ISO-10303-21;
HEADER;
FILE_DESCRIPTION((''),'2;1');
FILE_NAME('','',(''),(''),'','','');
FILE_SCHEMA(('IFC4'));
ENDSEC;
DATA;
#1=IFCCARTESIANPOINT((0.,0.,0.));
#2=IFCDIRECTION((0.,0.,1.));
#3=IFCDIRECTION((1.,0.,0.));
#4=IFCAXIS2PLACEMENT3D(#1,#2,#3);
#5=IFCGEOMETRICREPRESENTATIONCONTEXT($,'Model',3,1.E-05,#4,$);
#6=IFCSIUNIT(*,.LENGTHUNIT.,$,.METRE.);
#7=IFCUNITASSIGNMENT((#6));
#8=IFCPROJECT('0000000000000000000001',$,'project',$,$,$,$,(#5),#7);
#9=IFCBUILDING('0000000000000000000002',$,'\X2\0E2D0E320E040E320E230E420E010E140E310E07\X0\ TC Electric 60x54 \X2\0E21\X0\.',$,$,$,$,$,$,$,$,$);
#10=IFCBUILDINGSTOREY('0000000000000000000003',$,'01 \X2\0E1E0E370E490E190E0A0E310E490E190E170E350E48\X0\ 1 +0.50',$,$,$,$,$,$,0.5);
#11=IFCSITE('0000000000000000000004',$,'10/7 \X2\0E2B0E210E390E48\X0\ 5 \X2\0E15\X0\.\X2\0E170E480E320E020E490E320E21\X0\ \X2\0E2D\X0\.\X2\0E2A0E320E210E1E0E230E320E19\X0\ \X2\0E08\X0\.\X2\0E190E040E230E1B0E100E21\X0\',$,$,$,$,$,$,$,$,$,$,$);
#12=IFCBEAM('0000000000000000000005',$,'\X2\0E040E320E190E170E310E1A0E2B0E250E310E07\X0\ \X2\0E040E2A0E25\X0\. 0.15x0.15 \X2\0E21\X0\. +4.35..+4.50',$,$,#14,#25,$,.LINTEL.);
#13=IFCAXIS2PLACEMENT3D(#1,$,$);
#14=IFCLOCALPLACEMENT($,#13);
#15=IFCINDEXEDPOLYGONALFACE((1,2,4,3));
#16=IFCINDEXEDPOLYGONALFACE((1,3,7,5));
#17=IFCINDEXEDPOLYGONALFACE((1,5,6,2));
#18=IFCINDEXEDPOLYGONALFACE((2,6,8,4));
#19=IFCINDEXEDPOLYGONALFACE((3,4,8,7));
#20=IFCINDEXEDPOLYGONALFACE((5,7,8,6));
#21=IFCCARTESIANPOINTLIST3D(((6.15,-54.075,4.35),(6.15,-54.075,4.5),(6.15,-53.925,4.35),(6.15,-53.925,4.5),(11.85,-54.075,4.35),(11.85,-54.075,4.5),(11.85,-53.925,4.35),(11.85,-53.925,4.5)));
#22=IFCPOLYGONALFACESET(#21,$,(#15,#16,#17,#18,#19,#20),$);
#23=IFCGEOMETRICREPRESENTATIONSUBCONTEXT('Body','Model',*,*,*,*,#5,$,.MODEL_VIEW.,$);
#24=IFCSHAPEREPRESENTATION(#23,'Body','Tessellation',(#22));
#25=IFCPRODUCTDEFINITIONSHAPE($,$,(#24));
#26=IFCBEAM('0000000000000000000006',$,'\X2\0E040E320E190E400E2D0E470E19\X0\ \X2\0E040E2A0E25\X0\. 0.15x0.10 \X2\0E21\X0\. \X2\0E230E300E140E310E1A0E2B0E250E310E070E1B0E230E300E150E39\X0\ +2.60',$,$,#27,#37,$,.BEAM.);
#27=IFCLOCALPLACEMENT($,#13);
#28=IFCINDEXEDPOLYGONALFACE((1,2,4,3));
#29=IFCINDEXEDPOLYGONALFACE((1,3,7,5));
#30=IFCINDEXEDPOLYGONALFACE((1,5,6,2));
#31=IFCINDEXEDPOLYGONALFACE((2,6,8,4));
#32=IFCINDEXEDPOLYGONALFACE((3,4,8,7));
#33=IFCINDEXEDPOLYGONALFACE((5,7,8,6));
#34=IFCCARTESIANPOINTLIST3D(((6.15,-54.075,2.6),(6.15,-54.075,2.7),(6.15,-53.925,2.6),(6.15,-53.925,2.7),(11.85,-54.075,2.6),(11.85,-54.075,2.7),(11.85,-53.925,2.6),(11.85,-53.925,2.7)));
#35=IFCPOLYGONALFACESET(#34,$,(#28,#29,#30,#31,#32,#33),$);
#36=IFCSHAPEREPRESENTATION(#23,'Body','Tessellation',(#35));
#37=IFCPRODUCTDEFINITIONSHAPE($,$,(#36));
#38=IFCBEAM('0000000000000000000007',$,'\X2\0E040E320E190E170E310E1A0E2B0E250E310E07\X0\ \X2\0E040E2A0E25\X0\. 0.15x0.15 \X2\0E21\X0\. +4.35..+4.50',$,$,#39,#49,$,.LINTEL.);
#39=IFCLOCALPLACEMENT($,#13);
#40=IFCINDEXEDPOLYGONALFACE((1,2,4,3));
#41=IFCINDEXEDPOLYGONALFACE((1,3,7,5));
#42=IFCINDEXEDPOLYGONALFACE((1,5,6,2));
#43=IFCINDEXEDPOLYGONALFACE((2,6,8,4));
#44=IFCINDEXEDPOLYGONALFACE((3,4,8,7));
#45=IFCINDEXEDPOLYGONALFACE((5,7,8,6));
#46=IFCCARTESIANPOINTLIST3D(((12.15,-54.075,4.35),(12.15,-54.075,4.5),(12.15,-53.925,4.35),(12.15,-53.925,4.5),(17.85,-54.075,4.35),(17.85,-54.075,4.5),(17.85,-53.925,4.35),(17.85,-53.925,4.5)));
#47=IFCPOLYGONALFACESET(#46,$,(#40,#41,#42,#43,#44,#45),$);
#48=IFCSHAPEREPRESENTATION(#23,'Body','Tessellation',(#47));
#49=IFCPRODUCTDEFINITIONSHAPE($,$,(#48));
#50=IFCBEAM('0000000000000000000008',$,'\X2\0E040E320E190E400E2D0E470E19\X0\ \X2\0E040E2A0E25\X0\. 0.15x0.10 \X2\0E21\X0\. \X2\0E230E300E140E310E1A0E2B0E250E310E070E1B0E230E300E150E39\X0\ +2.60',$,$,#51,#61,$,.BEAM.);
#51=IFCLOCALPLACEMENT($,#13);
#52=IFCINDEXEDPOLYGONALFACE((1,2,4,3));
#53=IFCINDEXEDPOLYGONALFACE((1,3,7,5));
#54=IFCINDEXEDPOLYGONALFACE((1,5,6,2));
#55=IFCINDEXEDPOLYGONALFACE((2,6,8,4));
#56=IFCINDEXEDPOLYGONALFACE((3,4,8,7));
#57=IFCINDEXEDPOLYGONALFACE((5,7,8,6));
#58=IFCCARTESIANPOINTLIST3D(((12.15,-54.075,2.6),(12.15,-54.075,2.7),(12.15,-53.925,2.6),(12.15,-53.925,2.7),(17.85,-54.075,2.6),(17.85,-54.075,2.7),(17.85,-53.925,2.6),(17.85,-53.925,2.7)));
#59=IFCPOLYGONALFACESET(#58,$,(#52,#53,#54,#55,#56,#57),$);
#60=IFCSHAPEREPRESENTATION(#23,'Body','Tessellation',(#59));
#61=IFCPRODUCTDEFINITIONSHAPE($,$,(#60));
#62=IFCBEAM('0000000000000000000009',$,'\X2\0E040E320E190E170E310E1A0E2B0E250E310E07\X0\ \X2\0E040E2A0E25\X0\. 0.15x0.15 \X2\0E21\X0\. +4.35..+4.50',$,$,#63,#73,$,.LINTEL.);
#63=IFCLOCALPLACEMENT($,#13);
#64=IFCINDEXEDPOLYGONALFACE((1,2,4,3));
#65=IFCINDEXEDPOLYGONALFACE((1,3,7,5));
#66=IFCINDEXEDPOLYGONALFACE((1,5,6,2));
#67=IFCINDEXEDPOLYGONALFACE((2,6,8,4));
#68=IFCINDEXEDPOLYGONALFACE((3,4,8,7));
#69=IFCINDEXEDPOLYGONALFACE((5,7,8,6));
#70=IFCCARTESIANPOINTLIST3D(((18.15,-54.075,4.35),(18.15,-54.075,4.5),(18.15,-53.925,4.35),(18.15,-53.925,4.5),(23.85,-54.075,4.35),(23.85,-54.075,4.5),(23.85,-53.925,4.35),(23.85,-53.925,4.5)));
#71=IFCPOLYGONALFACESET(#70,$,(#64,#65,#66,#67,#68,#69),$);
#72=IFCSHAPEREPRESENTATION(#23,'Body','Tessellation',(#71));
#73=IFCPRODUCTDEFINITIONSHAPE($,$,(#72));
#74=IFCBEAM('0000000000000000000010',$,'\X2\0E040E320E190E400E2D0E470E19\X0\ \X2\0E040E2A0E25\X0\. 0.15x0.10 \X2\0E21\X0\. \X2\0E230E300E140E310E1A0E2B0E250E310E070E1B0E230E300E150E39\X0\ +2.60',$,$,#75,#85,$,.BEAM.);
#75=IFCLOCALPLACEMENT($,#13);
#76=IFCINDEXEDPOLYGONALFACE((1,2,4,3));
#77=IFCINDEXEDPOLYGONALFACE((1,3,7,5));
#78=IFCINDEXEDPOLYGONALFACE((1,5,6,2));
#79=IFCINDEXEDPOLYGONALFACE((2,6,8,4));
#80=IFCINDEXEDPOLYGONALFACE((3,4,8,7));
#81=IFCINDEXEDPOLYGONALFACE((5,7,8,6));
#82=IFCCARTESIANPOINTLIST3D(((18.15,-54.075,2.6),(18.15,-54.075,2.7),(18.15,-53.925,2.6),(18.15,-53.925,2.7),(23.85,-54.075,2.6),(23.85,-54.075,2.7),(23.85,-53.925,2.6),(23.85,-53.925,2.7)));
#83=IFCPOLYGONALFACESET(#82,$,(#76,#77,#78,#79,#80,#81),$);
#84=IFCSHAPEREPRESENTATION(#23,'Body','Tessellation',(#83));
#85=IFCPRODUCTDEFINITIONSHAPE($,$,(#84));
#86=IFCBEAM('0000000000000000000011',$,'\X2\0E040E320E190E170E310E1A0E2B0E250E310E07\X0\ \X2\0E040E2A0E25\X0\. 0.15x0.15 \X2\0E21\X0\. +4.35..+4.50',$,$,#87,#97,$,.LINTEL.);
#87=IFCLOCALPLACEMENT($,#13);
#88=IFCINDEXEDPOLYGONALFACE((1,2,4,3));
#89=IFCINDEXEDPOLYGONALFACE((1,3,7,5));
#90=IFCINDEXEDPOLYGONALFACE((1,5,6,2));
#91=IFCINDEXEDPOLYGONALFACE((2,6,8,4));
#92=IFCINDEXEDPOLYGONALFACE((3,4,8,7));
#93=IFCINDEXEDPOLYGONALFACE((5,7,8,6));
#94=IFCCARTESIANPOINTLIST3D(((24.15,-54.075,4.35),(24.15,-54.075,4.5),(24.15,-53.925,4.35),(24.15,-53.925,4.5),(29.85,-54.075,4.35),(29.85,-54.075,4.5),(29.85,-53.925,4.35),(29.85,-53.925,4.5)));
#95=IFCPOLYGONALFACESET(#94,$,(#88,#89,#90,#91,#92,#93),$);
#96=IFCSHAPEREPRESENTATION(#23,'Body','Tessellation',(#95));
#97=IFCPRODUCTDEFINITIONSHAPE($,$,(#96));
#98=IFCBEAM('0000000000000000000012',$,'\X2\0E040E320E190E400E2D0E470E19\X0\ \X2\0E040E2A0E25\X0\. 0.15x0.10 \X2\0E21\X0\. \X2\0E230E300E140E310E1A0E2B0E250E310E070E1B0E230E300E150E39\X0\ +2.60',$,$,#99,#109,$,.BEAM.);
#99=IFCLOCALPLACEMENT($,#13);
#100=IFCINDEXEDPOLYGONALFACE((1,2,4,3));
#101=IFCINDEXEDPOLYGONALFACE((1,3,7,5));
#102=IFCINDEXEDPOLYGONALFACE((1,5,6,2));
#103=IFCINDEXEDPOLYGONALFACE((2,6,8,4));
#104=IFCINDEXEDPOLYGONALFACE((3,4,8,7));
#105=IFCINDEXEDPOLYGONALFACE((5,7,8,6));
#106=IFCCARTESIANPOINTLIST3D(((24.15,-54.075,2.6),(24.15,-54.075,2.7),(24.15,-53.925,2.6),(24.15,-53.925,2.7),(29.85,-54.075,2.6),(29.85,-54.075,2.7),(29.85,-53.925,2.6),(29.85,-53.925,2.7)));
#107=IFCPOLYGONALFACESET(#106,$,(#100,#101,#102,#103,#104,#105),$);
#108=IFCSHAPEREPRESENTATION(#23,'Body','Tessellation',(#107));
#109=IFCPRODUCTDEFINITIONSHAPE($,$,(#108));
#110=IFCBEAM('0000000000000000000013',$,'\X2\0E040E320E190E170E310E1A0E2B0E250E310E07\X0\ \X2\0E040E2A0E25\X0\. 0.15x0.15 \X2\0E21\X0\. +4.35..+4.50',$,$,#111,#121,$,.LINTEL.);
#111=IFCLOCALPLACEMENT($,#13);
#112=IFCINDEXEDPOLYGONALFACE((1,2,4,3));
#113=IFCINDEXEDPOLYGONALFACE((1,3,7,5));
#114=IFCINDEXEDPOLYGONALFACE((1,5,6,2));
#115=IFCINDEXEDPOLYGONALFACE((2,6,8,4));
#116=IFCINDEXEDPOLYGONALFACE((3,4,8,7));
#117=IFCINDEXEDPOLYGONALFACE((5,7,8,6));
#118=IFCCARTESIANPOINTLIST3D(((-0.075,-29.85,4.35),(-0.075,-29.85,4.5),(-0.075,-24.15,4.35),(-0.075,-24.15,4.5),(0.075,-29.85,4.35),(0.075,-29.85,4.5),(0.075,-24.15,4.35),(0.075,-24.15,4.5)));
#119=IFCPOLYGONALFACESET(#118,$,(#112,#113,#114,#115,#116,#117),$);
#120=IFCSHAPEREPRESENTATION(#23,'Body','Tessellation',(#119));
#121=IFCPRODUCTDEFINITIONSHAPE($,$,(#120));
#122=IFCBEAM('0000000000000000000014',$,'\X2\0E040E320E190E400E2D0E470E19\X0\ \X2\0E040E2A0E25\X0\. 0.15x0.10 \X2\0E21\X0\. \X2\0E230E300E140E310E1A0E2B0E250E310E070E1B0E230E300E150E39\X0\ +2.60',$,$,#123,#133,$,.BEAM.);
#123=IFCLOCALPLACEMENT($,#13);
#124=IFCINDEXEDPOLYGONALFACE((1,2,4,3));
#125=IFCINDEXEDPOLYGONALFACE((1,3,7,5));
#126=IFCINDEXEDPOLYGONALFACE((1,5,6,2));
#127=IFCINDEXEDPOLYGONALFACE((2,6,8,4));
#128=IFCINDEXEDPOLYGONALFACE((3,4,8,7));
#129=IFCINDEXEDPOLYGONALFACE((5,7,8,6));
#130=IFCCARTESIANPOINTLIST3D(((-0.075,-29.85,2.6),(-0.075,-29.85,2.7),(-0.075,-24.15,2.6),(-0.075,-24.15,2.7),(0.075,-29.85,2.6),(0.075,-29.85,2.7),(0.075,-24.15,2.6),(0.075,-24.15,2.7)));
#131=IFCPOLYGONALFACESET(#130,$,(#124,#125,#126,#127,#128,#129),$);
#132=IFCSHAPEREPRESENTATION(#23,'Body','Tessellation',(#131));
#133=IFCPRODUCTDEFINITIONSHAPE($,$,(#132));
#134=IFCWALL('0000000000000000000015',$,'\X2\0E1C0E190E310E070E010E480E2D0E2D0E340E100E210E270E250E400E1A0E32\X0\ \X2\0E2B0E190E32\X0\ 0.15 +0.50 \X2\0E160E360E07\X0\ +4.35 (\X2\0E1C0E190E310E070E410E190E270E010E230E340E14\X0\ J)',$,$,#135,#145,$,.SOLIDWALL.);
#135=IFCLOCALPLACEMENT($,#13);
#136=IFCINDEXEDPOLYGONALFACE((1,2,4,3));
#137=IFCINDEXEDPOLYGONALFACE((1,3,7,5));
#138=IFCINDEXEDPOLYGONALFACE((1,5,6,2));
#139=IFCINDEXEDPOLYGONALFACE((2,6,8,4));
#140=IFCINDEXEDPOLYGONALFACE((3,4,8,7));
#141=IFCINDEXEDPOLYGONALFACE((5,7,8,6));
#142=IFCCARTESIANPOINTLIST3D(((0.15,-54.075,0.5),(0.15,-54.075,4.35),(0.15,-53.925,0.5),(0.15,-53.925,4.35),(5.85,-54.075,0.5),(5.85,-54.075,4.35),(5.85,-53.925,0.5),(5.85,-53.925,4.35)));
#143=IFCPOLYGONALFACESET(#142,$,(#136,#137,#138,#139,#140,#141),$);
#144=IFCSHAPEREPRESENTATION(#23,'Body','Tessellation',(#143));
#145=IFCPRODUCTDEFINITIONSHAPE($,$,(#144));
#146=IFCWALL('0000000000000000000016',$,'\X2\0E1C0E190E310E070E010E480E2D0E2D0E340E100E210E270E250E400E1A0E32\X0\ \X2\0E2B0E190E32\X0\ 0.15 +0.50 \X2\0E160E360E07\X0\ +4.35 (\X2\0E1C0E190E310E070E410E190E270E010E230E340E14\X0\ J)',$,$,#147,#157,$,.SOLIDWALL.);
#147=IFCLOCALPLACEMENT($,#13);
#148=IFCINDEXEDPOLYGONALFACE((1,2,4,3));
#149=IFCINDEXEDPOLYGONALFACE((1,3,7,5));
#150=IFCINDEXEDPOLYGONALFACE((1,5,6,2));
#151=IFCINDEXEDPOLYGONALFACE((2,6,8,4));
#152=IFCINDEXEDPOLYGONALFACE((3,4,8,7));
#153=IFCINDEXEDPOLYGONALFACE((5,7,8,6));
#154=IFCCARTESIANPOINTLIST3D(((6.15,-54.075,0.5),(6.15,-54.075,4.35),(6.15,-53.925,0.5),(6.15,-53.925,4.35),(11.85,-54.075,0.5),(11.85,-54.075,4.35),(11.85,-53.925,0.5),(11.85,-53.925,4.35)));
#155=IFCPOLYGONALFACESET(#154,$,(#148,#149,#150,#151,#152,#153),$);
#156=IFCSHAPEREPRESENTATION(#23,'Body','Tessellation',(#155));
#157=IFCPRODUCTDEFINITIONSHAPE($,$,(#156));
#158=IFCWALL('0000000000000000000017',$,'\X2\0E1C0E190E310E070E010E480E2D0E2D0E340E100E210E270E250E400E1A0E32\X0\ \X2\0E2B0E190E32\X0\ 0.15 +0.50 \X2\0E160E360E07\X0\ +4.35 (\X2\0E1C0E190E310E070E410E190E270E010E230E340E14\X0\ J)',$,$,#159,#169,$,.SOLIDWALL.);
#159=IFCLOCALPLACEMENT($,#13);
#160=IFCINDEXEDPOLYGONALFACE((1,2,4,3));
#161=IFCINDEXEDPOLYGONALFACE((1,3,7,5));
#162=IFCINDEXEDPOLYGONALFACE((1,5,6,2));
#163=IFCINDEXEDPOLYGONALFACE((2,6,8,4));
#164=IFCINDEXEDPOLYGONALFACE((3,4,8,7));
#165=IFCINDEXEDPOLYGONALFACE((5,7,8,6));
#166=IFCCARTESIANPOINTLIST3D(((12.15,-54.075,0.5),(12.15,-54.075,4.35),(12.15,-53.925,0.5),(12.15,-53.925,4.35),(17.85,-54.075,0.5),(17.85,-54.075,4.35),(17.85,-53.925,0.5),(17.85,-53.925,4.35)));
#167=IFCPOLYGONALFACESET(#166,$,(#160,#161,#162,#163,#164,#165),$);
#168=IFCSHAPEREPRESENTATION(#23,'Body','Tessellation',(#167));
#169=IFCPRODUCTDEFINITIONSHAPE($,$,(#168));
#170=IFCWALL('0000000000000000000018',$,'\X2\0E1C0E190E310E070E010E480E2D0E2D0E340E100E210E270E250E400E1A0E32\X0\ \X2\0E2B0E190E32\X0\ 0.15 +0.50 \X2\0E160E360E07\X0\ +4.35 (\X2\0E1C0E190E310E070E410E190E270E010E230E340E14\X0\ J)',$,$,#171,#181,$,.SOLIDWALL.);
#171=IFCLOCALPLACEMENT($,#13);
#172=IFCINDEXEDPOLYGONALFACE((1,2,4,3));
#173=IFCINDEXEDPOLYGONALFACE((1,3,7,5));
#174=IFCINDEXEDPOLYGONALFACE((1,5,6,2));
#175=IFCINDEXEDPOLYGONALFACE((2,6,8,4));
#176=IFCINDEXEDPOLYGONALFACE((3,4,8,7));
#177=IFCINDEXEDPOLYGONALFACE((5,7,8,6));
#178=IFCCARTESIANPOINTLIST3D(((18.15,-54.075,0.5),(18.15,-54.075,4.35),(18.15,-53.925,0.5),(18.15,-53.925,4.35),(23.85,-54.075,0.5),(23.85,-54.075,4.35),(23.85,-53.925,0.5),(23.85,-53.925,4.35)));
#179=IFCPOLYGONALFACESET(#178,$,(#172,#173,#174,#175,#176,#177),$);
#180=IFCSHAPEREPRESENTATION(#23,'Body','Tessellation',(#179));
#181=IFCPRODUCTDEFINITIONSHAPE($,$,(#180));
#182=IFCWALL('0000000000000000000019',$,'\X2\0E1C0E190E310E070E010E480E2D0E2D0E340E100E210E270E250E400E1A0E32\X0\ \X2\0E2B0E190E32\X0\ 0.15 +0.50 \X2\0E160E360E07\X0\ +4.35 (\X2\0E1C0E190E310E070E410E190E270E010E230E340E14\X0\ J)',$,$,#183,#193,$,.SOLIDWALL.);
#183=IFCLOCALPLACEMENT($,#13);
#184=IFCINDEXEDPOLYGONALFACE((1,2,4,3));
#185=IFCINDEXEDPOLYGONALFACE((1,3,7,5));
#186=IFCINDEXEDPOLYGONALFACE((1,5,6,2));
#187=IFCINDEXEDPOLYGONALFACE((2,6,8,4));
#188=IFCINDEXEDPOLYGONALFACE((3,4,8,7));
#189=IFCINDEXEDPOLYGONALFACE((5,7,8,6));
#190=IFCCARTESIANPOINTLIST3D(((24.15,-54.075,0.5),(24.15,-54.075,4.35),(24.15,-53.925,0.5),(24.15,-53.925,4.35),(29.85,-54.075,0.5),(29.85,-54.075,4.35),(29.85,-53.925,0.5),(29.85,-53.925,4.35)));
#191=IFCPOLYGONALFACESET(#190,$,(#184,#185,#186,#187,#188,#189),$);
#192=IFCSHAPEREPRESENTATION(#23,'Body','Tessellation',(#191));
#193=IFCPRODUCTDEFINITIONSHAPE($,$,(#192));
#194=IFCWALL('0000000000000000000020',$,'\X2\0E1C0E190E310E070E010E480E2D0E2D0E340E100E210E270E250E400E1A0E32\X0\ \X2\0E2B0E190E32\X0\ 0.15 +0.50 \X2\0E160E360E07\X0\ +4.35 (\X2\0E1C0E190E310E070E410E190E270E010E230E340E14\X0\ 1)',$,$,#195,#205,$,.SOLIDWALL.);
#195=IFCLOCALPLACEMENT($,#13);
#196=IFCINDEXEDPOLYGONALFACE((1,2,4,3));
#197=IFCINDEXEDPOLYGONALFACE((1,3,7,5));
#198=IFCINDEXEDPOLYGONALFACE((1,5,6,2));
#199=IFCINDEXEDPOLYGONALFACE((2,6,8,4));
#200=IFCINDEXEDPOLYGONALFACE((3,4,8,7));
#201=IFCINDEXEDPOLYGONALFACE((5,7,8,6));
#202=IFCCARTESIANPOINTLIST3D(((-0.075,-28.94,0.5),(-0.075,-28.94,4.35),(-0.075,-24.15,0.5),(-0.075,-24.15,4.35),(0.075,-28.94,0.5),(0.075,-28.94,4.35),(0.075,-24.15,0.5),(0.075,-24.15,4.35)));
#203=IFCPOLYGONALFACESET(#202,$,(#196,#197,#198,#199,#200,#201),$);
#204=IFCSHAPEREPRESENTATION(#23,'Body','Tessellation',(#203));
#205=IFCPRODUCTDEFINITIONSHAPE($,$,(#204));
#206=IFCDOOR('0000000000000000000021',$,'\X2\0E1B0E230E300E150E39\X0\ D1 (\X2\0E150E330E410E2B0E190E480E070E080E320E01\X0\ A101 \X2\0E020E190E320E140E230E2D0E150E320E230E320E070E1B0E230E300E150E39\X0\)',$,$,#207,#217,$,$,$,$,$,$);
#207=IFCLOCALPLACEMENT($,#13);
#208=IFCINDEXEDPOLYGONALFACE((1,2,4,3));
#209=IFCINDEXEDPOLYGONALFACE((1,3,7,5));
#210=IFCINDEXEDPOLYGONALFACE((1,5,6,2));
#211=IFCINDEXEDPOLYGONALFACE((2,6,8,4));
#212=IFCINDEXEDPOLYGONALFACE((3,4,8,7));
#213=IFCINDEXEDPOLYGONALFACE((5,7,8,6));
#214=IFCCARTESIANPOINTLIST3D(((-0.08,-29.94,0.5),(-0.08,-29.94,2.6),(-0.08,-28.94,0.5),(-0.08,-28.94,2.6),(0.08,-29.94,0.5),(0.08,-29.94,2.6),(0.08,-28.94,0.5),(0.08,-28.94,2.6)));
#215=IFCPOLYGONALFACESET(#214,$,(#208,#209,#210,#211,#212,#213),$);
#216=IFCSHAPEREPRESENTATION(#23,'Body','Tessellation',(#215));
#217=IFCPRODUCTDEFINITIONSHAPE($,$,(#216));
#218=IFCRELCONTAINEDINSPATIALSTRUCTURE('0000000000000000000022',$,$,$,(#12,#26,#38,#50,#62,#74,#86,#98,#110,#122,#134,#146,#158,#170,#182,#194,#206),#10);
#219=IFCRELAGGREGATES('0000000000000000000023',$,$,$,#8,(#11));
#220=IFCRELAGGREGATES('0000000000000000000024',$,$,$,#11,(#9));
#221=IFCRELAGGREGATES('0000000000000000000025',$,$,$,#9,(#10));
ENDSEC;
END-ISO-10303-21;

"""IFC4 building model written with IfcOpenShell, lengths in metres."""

from ifc_helpers import new_model, si_unit, frame, origin, origin_with_axes, origin_2d, place, context, subcontext, project, spatial, rectangle, extrude, element, save


model = new_model("IFC4")

# Units and contexts
model_context = context("Model", 3, precision=1e-05, world=origin_with_axes())
body_context = subcontext(model_context, "Body", "Model", "MODEL_VIEW")
ifc_project = project(units=[si_unit("LENGTHUNIT", "METRE")], contexts=[model_context])

# Site, building, storey
site = spatial("IfcSite", under=ifc_project, Name="10/7 หมู่ 5 ต.ท่าข้าม อ.สามพราน จ.นครปฐม")
building = spatial("IfcBuilding", under=site, Name="อาคารโกดัง TC Electric 60x54 ม.")
storey = spatial("IfcBuildingStorey", under=building, Name="01 พื้นชั้นที่ 1 +0.50", Elevation=0.5)

# Beams
beam_1_placement = place(None, frame((6.15, -54.0, 4.425), z_axis=(1.0, 0.0, 0.0), x_axis=(0.0, -1.0, 0.0)))
element("IfcBeam", 1, at=beam_1_placement, inside=storey, Name="คานทับหลัง คสล. 0.15x0.15 ม. +4.35..+4.50", PredefinedType="LINTEL", context=body_context, shape_type="SweptSolid", body=[
    extrude(rectangle(XDim=0.15, YDim=0.15, at=origin_2d()), origin(), (0.0, 0.0, 1.0), 5.7),
])
beam_2_placement = place(None, frame((6.15, -54.0, 2.65), z_axis=(1.0, 0.0, 0.0), x_axis=(0.0, -1.0, 0.0)))
element("IfcBeam", 2, at=beam_2_placement, inside=storey, Name="คานเอ็น คสล. 0.15x0.10 ม. ระดับหลังประตู +2.60", PredefinedType="BEAM", context=body_context, shape_type="SweptSolid", body=[
    extrude(rectangle(XDim=0.15, YDim=0.1, at=origin_2d()), origin(), (0.0, 0.0, 1.0), 5.7),
])
beam_3_placement = place(None, frame((12.15, -54.0, 4.425), z_axis=(1.0, 0.0, 0.0), x_axis=(0.0, -1.0, 0.0)))
element("IfcBeam", 3, at=beam_3_placement, inside=storey, Name="คานทับหลัง คสล. 0.15x0.15 ม. +4.35..+4.50", PredefinedType="LINTEL", context=body_context, shape_type="SweptSolid", body=[
    extrude(rectangle(XDim=0.15, YDim=0.15, at=origin_2d()), origin(), (0.0, 0.0, 1.0), 5.7),
])
beam_4_placement = place(None, frame((12.15, -54.0, 2.65), z_axis=(1.0, 0.0, 0.0), x_axis=(0.0, -1.0, 0.0)))
element("IfcBeam", 4, at=beam_4_placement, inside=storey, Name="คานเอ็น คสล. 0.15x0.10 ม. ระดับหลังประตู +2.60", PredefinedType="BEAM", context=body_context, shape_type="SweptSolid", body=[
    extrude(rectangle(XDim=0.15, YDim=0.1, at=origin_2d()), origin(), (0.0, 0.0, 1.0), 5.7),
])
beam_5_placement = place(None, frame((18.15, -54.0, 4.425), z_axis=(1.0, 0.0, 0.0), x_axis=(0.0, -1.0, 0.0)))
element("IfcBeam", 5, at=beam_5_placement, inside=storey, Name="คานทับหลัง คสล. 0.15x0.15 ม. +4.35..+4.50", PredefinedType="LINTEL", context=body_context, shape_type="SweptSolid", body=[
    extrude(rectangle(XDim=0.15, YDim=0.15, at=origin_2d()), origin(), (0.0, 0.0, 1.0), 5.7),
])
beam_6_placement = place(None, frame((18.15, -54.0, 2.65), z_axis=(1.0, 0.0, 0.0), x_axis=(0.0, -1.0, 0.0)))
element("IfcBeam", 6, at=beam_6_placement, inside=storey, Name="คานเอ็น คสล. 0.15x0.10 ม. ระดับหลังประตู +2.60", PredefinedType="BEAM", context=body_context, shape_type="SweptSolid", body=[
    extrude(rectangle(XDim=0.15, YDim=0.1, at=origin_2d()), origin(), (0.0, 0.0, 1.0), 5.7),
])
beam_7_placement = place(None, frame((24.15, -54.0, 4.425), z_axis=(1.0, 0.0, 0.0), x_axis=(0.0, -1.0, 0.0)))
element("IfcBeam", 7, at=beam_7_placement, inside=storey, Name="คานทับหลัง คสล. 0.15x0.15 ม. +4.35..+4.50", PredefinedType="LINTEL", context=body_context, shape_type="SweptSolid", body=[
    extrude(rectangle(XDim=0.15, YDim=0.15, at=origin_2d()), origin(), (0.0, 0.0, 1.0), 5.7),
])
beam_8_placement = place(None, frame((24.15, -54.0, 2.65), z_axis=(1.0, 0.0, 0.0), x_axis=(0.0, -1.0, 0.0)))
element("IfcBeam", 8, at=beam_8_placement, inside=storey, Name="คานเอ็น คสล. 0.15x0.10 ม. ระดับหลังประตู +2.60", PredefinedType="BEAM", context=body_context, shape_type="SweptSolid", body=[
    extrude(rectangle(XDim=0.15, YDim=0.1, at=origin_2d()), origin(), (0.0, 0.0, 1.0), 5.7),
])
beam_9_placement = place(None, frame((0.0, -24.15, 4.425), z_axis=(0.0, -1.0, 0.0), x_axis=(-1.0, 0.0, 0.0)))
element("IfcBeam", 9, at=beam_9_placement, inside=storey, Name="คานทับหลัง คสล. 0.15x0.15 ม. +4.35..+4.50", PredefinedType="LINTEL", context=body_context, shape_type="SweptSolid", body=[
    extrude(rectangle(XDim=0.15, YDim=0.15, at=origin_2d()), origin(), (0.0, 0.0, 1.0), 5.7),
])
beam_10_placement = place(None, frame((0.0, -24.15, 2.65), z_axis=(0.0, -1.0, 0.0), x_axis=(-1.0, 0.0, 0.0)))
element("IfcBeam", 10, at=beam_10_placement, inside=storey, Name="คานเอ็น คสล. 0.15x0.10 ม. ระดับหลังประตู +2.60", PredefinedType="BEAM", context=body_context, shape_type="SweptSolid", body=[
    extrude(rectangle(XDim=0.15, YDim=0.1, at=origin_2d()), origin(), (0.0, 0.0, 1.0), 5.7),
])

# Walls
for number, where, z_axis, x_axis, name in (
    (11, (3.0, -54.0, 0.5), (0.0, 0.0, 1.0), (1.0, 0.0, 0.0), "ผนังก่ออิฐมวลเบา หนา 0.15 +0.50 ถึง +4.35 (ผนังแนวกริด J)"),
    (12, (9.0, -54.0, 0.5), (0.0, 0.0, 1.0), (1.0, 0.0, 0.0), "ผนังก่ออิฐมวลเบา หนา 0.15 +0.50 ถึง +4.35 (ผนังแนวกริด J)"),
    (13, (15.0, -54.0, 0.5), (0.0, 0.0, 1.0), (1.0, 0.0, 0.0), "ผนังก่ออิฐมวลเบา หนา 0.15 +0.50 ถึง +4.35 (ผนังแนวกริด J)"),
    (14, (21.0, -54.0, 0.5), (0.0, 0.0, 1.0), (1.0, 0.0, 0.0), "ผนังก่ออิฐมวลเบา หนา 0.15 +0.50 ถึง +4.35 (ผนังแนวกริด J)"),
    (15, (27.0, -54.0, 0.5), (0.0, 0.0, 1.0), (1.0, 0.0, 0.0), "ผนังก่ออิฐมวลเบา หนา 0.15 +0.50 ถึง +4.35 (ผนังแนวกริด J)"),
):
    element("IfcWall", number, at=place(None, frame(where, z_axis=z_axis, x_axis=x_axis)), inside=storey, Name=name, PredefinedType="SOLIDWALL", context=body_context, shape_type="SweptSolid", body=[
        extrude(rectangle(XDim=5.7, YDim=0.15, at=origin_2d()), origin(), (0.0, 0.0, 1.0), 3.85),
    ])
wall_placement = place(None, frame((0.0, -26.545, 0.5), z_axis=(0.0, 0.0, 1.0), x_axis=(1.0, 0.0, 0.0)))
element("IfcWall", 16, at=wall_placement, inside=storey, Name="ผนังก่ออิฐมวลเบา หนา 0.15 +0.50 ถึง +4.35 (ผนังแนวกริด 1)", PredefinedType="SOLIDWALL", context=body_context, shape_type="SweptSolid", body=[
    extrude(rectangle(XDim=0.15, YDim=4.79, at=origin_2d()), origin(), (0.0, 0.0, 1.0), 3.85),
])

# Door
door_placement = place(None, frame((0.0, -29.44, 0.5), z_axis=(0.0, 0.0, 1.0), x_axis=(1.0, 0.0, 0.0)))
element("IfcDoor", 17, at=door_placement, inside=storey, Name="ประตู D1 (ตำแหน่งจาก A101 ขนาดรอตารางประตู)", context=body_context, shape_type="SweptSolid", body=[
    extrude(rectangle(XDim=0.16, YDim=1.0, at=origin_2d()), origin(), (0.0, 0.0, 1.0), 2.1),
])

save(model, "model.ifc")
